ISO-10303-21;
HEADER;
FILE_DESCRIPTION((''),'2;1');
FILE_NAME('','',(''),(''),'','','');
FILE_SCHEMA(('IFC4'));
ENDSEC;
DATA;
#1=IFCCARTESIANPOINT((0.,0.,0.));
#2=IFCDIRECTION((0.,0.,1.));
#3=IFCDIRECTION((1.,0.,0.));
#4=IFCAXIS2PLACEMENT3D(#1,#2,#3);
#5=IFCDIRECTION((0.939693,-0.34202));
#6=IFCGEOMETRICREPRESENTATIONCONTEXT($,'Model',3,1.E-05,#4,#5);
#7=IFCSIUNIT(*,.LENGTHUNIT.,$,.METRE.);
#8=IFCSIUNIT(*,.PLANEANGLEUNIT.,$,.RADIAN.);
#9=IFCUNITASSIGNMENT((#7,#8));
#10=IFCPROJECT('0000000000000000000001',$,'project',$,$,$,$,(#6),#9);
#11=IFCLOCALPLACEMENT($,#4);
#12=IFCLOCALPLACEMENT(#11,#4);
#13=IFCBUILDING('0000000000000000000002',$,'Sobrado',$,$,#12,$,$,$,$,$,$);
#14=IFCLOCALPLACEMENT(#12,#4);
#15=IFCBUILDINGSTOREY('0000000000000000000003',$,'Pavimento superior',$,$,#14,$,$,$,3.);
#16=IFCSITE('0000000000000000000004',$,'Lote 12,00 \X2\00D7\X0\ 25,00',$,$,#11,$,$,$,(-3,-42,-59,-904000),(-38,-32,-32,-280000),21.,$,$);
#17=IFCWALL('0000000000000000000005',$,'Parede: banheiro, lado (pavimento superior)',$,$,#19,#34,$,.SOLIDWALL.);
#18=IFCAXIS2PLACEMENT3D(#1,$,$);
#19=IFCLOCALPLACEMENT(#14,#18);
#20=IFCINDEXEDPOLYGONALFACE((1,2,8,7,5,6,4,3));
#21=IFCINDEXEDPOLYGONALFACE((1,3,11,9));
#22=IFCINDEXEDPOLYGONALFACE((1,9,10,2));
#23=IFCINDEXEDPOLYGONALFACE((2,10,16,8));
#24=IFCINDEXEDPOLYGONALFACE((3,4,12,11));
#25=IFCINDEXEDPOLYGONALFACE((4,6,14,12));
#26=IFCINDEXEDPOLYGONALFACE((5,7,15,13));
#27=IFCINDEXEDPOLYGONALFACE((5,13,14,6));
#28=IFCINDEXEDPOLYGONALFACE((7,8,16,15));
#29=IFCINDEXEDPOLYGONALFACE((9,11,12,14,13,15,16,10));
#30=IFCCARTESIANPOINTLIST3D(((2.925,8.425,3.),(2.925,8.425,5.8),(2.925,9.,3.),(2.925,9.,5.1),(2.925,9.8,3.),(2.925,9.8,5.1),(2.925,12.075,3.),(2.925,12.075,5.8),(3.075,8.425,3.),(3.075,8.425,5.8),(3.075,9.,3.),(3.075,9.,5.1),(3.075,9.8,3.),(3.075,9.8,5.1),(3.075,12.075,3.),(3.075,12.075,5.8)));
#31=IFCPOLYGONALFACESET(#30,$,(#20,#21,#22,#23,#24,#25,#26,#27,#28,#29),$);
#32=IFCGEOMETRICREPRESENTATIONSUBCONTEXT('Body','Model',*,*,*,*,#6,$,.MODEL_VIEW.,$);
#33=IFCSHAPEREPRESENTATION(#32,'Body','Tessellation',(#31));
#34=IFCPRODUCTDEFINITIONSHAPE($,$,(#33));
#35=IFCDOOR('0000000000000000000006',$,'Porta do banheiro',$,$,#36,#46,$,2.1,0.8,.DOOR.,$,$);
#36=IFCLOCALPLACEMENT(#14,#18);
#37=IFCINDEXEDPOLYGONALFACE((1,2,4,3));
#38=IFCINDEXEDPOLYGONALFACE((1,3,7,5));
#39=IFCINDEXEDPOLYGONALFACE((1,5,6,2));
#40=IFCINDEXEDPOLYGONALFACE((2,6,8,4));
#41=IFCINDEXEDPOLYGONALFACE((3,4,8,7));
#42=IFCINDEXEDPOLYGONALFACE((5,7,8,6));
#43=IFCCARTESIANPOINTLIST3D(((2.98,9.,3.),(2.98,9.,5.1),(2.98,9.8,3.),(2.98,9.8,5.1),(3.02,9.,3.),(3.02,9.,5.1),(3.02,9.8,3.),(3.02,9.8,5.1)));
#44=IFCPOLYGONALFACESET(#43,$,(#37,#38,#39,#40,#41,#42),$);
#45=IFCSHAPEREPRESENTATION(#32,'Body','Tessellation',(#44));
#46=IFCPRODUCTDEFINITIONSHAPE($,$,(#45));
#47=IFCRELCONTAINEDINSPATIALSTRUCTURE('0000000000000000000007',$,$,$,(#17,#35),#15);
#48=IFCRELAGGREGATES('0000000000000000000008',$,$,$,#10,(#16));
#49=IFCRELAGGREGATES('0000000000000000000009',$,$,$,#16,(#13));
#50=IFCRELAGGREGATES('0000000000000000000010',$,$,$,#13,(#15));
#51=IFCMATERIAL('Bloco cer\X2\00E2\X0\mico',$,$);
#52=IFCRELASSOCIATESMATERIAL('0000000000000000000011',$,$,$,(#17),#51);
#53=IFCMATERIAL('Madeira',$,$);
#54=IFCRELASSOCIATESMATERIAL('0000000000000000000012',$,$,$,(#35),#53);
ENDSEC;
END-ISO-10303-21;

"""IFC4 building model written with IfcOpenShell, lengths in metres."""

from ifc_helpers import new_model, si_unit, direction, frame, origin_with_axes, place, context, subcontext, project, spatial, line, indexed_curve, outline, extrude, material, element, fill, save


model = new_model("IFC4")

# Units and contexts
model_context = context("Model", 3, precision=1e-05, world=origin_with_axes(), true_north=direction((0.939693, -0.34202)))
body_context = subcontext(model_context, "Body", "Model", "MODEL_VIEW")
ifc_project = project(units=[si_unit("LENGTHUNIT", "METRE"), si_unit("PLANEANGLEUNIT", "RADIAN")], contexts=[model_context])

# Site, building, storey
site_placement = place(None, origin_with_axes())
site = spatial("IfcSite", under=ifc_project, at=site_placement, Name="Lote 12,00 × 25,00", RefLatitude=(-3, -42, -59, -904000), RefLongitude=(-38, -32, -32, -280000), RefElevation=21.0)
building_placement = place(site_placement, origin_with_axes())
building = spatial("IfcBuilding", under=site, at=building_placement, Name="Sobrado")
storey_placement = place(building_placement, origin_with_axes())
storey = spatial("IfcBuildingStorey", under=building, at=storey_placement, Name="Pavimento superior", Elevation=3.0)

# Shared definitions
ifc_material_1 = material(Name="Concreto armado")

# Shared definitions
ifc_material_2 = material(Name="Bloco cerâmico")

# Shared definitions
ifc_material_3 = material(Name="Madeira")

# Wall, opening, door
wall_1_placement = place(storey_placement, origin_with_axes())
wall_1 = element("IfcWall", 1, at=wall_1_placement, inside=storey, material=ifc_material_2, Name="Parede: banheiro, lado (pavimento superior)", PredefinedType="SOLIDWALL", context=body_context, shape_type="SweptSolid", body=[
    extrude(outline(indexed_curve([(2.925, 8.425), (3.075, 8.425), (3.075, 12.075), (2.925, 12.075)], segments=[line(1, 2, 3, 4, 1)])), frame((0.0, 0.0, 3.0), z_axis=(0.0, 0.0, 1.0), x_axis=(1.0, 0.0, 0.0)), (0.0, 0.0, 1.0), 2.8),
])
opening_1_placement = place(wall_1_placement, origin_with_axes())
opening_1 = element("IfcOpeningElement", 2, at=opening_1_placement, cuts=wall_1, material=ifc_material_1, PredefinedType="OPENING", context=body_context, shape_type="SweptSolid", body=[
    extrude(outline(indexed_curve([(2.875, 9.0), (3.125, 9.0), (3.125, 9.8), (2.875, 9.8)], segments=[line(1, 2, 3, 4, 1)])), frame((0.0, 0.0, 3.0), z_axis=(0.0, 0.0, 1.0), x_axis=(1.0, 0.0, 0.0)), (0.0, 0.0, 1.0), 2.1),
])
door_1_placement = place(storey_placement, origin_with_axes())
door_1 = element("IfcDoor", 3, at=door_1_placement, inside=storey, material=ifc_material_3, Name="Porta do banheiro", OverallHeight=2.1, OverallWidth=0.8, PredefinedType="DOOR", context=body_context, shape_type="SweptSolid", body=[
    extrude(outline(indexed_curve([(2.98, 9.0), (3.02, 9.0), (3.02, 9.8), (2.98, 9.8)], segments=[line(1, 2, 3, 4, 1)])), frame((0.0, 0.0, 3.0), z_axis=(0.0, 0.0, 1.0), x_axis=(1.0, 0.0, 0.0)), (0.0, 0.0, 1.0), 2.1),
])
fill(opening_1, door_1)

save(model, "model.ifc")
